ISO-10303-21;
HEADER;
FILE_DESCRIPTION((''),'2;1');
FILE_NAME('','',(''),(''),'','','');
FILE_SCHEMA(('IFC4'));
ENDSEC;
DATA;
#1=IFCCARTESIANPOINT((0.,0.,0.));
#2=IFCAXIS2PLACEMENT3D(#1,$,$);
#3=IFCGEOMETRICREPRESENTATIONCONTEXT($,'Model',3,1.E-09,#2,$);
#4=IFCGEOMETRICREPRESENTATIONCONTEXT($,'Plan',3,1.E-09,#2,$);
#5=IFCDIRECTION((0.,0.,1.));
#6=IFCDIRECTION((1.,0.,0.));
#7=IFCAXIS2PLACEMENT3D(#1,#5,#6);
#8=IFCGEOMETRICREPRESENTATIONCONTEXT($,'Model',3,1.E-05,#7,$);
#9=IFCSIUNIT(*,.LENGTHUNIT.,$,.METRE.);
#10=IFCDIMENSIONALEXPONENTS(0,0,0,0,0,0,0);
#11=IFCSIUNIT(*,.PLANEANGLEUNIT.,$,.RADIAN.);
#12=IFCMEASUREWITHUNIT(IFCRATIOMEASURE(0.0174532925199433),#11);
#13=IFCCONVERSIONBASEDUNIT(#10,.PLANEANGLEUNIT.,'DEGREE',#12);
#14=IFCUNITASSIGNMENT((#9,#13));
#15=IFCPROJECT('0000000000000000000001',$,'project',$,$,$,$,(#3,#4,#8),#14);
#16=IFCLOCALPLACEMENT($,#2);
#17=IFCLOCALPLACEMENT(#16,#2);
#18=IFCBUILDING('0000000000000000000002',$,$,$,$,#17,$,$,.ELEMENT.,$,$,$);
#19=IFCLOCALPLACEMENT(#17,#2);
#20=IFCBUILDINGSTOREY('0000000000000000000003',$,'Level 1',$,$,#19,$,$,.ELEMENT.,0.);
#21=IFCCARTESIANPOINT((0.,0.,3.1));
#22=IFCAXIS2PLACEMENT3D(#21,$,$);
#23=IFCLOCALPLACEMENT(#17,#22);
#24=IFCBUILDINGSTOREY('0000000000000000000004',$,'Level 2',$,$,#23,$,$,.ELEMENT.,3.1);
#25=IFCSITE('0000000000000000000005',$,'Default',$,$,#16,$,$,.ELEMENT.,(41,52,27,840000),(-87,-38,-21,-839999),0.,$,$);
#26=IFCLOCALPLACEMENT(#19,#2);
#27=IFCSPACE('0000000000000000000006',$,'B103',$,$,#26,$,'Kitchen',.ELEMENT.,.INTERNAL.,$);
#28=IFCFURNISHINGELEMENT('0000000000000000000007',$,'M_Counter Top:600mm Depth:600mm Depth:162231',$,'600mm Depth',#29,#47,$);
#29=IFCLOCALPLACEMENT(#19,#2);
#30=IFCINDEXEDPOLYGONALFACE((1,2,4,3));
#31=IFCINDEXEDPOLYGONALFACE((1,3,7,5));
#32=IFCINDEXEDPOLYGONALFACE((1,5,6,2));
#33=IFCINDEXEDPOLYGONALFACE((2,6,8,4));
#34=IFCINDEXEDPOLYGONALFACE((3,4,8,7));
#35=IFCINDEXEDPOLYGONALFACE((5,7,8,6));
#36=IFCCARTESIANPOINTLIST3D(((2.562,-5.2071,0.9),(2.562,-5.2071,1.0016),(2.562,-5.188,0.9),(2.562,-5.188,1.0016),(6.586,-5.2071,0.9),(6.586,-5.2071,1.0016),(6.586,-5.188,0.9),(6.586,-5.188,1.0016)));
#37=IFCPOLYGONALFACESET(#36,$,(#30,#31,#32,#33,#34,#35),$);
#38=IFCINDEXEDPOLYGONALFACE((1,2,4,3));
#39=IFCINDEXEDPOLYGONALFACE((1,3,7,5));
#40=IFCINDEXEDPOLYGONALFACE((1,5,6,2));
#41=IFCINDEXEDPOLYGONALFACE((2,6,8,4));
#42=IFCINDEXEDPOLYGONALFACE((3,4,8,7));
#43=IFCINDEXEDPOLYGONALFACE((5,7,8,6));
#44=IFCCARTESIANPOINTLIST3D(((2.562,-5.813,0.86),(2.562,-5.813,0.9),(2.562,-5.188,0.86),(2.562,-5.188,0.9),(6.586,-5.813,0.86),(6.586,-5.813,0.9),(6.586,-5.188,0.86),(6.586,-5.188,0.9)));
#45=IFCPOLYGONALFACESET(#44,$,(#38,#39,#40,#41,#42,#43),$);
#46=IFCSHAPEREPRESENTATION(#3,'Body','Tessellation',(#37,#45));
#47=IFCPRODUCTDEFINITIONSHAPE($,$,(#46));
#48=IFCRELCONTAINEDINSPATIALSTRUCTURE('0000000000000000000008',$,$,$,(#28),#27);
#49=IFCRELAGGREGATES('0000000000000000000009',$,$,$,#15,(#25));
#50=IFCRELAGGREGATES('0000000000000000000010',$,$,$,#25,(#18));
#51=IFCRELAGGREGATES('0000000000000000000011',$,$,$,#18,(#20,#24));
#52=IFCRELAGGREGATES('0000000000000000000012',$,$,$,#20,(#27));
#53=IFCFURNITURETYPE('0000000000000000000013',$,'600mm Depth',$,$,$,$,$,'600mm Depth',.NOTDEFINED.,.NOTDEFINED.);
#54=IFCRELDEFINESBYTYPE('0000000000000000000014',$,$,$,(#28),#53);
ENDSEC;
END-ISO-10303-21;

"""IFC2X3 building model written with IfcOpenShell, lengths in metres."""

from ifc_helpers import new_model, entity, si_unit, converted_unit, frame, origin, origin_with_axes, origin_2d_with_axis, place, context, project, spatial, rectangle, extrude, source, transform, mapped, type_object, type_shapes, element, save


model = new_model("IFC2X3")

# Units and contexts
model_context_1 = context("Model", 3, precision=1e-09, world=origin())
plan_context = context("Plan", 3, precision=1e-09, world=origin())
model_context_2 = context("Model", 3, precision=1e-05, world=origin_with_axes())
ifc_project = project(units=[si_unit("LENGTHUNIT", "METRE"), converted_unit("PLANEANGLEUNIT", "DEGREE", entity("IfcRatioMeasure", 0.0174532925199433), si_unit("PLANEANGLEUNIT", "RADIAN"), dimensions=[0, 0, 0, 0, 0, 0, 0])], contexts=[model_context_1, plan_context, model_context_2])

# Site, building, storey
site_placement = place(None, origin())
site = spatial("IfcSite", under=ifc_project, at=site_placement, Name="Default", CompositionType="ELEMENT", RefLatitude=(41, 52, 27, 840000), RefLongitude=(-87, -38, -21, -839999), RefElevation=0.0)
building_placement = place(site_placement, origin())
building = spatial("IfcBuilding", under=site, at=building_placement, CompositionType="ELEMENT")
storey_1_placement = place(building_placement, origin())
storey_1 = spatial("IfcBuildingStorey", under=building, at=storey_1_placement, Name="Level 1", CompositionType="ELEMENT", Elevation=0.0)

# Shared definitions
storey_2_placement = place(building_placement, frame((0.0, 0.0, 3.1)))
storey_2 = spatial("IfcBuildingStorey", under=building, at=storey_2_placement, Name="Level 2", CompositionType="ELEMENT", Elevation=3.1)

# Shared definitions
space_1_placement = place(storey_1_placement, origin())
space_1 = spatial("IfcSpace", under=storey_1, at=space_1_placement, Name="B103", LongName="Kitchen", CompositionType="ELEMENT", InteriorOrExteriorSpace="INTERNAL")

# Furnishing element
furniture_type_1 = type_object("IfcFurnitureType", Name="600mm Depth", ElementType="600mm Depth", AssemblyPlace="NOTDEFINED")
shared_shape_1 = source(origin(), model_context_1, "Body", "SweptSolid", [
    extrude(rectangle(XDim=0.0191, YDim=4.024, at=origin_2d_with_axis()), frame((0.8115, -0.0095, 0.9), z_axis=(0.0, 0.0, 1.0), x_axis=(0.0, -1.0, 0.0)), (0.0, 0.0, 1.0), 0.1016),
    extrude(rectangle(XDim=4.024, YDim=0.625, at=origin_2d_with_axis()), frame((0.8115, -0.3125, 0.86), z_axis=(0.0, 0.0, 1.0), x_axis=(-1.0, 0.0, 0.0)), (0.0, 0.0, 1.0), 0.04),
])
type_shapes(furniture_type_1, [shared_shape_1])
furnishing_1_placement = place(space_1_placement, frame((3.7625, -5.188, 0.0)))
element("IfcFurnishingElement", 1, at=furnishing_1_placement, inside=space_1, type_object=furniture_type_1, Name="M_Counter Top:600mm Depth:600mm Depth:162231", ObjectType="600mm Depth", context=model_context_1, shape_type="MappedRepresentation", body=[
    mapped(shared_shape_1, transform((0.0, 0.0, 0.0), scale=1.0)),
])

save(model, "model.ifc")
